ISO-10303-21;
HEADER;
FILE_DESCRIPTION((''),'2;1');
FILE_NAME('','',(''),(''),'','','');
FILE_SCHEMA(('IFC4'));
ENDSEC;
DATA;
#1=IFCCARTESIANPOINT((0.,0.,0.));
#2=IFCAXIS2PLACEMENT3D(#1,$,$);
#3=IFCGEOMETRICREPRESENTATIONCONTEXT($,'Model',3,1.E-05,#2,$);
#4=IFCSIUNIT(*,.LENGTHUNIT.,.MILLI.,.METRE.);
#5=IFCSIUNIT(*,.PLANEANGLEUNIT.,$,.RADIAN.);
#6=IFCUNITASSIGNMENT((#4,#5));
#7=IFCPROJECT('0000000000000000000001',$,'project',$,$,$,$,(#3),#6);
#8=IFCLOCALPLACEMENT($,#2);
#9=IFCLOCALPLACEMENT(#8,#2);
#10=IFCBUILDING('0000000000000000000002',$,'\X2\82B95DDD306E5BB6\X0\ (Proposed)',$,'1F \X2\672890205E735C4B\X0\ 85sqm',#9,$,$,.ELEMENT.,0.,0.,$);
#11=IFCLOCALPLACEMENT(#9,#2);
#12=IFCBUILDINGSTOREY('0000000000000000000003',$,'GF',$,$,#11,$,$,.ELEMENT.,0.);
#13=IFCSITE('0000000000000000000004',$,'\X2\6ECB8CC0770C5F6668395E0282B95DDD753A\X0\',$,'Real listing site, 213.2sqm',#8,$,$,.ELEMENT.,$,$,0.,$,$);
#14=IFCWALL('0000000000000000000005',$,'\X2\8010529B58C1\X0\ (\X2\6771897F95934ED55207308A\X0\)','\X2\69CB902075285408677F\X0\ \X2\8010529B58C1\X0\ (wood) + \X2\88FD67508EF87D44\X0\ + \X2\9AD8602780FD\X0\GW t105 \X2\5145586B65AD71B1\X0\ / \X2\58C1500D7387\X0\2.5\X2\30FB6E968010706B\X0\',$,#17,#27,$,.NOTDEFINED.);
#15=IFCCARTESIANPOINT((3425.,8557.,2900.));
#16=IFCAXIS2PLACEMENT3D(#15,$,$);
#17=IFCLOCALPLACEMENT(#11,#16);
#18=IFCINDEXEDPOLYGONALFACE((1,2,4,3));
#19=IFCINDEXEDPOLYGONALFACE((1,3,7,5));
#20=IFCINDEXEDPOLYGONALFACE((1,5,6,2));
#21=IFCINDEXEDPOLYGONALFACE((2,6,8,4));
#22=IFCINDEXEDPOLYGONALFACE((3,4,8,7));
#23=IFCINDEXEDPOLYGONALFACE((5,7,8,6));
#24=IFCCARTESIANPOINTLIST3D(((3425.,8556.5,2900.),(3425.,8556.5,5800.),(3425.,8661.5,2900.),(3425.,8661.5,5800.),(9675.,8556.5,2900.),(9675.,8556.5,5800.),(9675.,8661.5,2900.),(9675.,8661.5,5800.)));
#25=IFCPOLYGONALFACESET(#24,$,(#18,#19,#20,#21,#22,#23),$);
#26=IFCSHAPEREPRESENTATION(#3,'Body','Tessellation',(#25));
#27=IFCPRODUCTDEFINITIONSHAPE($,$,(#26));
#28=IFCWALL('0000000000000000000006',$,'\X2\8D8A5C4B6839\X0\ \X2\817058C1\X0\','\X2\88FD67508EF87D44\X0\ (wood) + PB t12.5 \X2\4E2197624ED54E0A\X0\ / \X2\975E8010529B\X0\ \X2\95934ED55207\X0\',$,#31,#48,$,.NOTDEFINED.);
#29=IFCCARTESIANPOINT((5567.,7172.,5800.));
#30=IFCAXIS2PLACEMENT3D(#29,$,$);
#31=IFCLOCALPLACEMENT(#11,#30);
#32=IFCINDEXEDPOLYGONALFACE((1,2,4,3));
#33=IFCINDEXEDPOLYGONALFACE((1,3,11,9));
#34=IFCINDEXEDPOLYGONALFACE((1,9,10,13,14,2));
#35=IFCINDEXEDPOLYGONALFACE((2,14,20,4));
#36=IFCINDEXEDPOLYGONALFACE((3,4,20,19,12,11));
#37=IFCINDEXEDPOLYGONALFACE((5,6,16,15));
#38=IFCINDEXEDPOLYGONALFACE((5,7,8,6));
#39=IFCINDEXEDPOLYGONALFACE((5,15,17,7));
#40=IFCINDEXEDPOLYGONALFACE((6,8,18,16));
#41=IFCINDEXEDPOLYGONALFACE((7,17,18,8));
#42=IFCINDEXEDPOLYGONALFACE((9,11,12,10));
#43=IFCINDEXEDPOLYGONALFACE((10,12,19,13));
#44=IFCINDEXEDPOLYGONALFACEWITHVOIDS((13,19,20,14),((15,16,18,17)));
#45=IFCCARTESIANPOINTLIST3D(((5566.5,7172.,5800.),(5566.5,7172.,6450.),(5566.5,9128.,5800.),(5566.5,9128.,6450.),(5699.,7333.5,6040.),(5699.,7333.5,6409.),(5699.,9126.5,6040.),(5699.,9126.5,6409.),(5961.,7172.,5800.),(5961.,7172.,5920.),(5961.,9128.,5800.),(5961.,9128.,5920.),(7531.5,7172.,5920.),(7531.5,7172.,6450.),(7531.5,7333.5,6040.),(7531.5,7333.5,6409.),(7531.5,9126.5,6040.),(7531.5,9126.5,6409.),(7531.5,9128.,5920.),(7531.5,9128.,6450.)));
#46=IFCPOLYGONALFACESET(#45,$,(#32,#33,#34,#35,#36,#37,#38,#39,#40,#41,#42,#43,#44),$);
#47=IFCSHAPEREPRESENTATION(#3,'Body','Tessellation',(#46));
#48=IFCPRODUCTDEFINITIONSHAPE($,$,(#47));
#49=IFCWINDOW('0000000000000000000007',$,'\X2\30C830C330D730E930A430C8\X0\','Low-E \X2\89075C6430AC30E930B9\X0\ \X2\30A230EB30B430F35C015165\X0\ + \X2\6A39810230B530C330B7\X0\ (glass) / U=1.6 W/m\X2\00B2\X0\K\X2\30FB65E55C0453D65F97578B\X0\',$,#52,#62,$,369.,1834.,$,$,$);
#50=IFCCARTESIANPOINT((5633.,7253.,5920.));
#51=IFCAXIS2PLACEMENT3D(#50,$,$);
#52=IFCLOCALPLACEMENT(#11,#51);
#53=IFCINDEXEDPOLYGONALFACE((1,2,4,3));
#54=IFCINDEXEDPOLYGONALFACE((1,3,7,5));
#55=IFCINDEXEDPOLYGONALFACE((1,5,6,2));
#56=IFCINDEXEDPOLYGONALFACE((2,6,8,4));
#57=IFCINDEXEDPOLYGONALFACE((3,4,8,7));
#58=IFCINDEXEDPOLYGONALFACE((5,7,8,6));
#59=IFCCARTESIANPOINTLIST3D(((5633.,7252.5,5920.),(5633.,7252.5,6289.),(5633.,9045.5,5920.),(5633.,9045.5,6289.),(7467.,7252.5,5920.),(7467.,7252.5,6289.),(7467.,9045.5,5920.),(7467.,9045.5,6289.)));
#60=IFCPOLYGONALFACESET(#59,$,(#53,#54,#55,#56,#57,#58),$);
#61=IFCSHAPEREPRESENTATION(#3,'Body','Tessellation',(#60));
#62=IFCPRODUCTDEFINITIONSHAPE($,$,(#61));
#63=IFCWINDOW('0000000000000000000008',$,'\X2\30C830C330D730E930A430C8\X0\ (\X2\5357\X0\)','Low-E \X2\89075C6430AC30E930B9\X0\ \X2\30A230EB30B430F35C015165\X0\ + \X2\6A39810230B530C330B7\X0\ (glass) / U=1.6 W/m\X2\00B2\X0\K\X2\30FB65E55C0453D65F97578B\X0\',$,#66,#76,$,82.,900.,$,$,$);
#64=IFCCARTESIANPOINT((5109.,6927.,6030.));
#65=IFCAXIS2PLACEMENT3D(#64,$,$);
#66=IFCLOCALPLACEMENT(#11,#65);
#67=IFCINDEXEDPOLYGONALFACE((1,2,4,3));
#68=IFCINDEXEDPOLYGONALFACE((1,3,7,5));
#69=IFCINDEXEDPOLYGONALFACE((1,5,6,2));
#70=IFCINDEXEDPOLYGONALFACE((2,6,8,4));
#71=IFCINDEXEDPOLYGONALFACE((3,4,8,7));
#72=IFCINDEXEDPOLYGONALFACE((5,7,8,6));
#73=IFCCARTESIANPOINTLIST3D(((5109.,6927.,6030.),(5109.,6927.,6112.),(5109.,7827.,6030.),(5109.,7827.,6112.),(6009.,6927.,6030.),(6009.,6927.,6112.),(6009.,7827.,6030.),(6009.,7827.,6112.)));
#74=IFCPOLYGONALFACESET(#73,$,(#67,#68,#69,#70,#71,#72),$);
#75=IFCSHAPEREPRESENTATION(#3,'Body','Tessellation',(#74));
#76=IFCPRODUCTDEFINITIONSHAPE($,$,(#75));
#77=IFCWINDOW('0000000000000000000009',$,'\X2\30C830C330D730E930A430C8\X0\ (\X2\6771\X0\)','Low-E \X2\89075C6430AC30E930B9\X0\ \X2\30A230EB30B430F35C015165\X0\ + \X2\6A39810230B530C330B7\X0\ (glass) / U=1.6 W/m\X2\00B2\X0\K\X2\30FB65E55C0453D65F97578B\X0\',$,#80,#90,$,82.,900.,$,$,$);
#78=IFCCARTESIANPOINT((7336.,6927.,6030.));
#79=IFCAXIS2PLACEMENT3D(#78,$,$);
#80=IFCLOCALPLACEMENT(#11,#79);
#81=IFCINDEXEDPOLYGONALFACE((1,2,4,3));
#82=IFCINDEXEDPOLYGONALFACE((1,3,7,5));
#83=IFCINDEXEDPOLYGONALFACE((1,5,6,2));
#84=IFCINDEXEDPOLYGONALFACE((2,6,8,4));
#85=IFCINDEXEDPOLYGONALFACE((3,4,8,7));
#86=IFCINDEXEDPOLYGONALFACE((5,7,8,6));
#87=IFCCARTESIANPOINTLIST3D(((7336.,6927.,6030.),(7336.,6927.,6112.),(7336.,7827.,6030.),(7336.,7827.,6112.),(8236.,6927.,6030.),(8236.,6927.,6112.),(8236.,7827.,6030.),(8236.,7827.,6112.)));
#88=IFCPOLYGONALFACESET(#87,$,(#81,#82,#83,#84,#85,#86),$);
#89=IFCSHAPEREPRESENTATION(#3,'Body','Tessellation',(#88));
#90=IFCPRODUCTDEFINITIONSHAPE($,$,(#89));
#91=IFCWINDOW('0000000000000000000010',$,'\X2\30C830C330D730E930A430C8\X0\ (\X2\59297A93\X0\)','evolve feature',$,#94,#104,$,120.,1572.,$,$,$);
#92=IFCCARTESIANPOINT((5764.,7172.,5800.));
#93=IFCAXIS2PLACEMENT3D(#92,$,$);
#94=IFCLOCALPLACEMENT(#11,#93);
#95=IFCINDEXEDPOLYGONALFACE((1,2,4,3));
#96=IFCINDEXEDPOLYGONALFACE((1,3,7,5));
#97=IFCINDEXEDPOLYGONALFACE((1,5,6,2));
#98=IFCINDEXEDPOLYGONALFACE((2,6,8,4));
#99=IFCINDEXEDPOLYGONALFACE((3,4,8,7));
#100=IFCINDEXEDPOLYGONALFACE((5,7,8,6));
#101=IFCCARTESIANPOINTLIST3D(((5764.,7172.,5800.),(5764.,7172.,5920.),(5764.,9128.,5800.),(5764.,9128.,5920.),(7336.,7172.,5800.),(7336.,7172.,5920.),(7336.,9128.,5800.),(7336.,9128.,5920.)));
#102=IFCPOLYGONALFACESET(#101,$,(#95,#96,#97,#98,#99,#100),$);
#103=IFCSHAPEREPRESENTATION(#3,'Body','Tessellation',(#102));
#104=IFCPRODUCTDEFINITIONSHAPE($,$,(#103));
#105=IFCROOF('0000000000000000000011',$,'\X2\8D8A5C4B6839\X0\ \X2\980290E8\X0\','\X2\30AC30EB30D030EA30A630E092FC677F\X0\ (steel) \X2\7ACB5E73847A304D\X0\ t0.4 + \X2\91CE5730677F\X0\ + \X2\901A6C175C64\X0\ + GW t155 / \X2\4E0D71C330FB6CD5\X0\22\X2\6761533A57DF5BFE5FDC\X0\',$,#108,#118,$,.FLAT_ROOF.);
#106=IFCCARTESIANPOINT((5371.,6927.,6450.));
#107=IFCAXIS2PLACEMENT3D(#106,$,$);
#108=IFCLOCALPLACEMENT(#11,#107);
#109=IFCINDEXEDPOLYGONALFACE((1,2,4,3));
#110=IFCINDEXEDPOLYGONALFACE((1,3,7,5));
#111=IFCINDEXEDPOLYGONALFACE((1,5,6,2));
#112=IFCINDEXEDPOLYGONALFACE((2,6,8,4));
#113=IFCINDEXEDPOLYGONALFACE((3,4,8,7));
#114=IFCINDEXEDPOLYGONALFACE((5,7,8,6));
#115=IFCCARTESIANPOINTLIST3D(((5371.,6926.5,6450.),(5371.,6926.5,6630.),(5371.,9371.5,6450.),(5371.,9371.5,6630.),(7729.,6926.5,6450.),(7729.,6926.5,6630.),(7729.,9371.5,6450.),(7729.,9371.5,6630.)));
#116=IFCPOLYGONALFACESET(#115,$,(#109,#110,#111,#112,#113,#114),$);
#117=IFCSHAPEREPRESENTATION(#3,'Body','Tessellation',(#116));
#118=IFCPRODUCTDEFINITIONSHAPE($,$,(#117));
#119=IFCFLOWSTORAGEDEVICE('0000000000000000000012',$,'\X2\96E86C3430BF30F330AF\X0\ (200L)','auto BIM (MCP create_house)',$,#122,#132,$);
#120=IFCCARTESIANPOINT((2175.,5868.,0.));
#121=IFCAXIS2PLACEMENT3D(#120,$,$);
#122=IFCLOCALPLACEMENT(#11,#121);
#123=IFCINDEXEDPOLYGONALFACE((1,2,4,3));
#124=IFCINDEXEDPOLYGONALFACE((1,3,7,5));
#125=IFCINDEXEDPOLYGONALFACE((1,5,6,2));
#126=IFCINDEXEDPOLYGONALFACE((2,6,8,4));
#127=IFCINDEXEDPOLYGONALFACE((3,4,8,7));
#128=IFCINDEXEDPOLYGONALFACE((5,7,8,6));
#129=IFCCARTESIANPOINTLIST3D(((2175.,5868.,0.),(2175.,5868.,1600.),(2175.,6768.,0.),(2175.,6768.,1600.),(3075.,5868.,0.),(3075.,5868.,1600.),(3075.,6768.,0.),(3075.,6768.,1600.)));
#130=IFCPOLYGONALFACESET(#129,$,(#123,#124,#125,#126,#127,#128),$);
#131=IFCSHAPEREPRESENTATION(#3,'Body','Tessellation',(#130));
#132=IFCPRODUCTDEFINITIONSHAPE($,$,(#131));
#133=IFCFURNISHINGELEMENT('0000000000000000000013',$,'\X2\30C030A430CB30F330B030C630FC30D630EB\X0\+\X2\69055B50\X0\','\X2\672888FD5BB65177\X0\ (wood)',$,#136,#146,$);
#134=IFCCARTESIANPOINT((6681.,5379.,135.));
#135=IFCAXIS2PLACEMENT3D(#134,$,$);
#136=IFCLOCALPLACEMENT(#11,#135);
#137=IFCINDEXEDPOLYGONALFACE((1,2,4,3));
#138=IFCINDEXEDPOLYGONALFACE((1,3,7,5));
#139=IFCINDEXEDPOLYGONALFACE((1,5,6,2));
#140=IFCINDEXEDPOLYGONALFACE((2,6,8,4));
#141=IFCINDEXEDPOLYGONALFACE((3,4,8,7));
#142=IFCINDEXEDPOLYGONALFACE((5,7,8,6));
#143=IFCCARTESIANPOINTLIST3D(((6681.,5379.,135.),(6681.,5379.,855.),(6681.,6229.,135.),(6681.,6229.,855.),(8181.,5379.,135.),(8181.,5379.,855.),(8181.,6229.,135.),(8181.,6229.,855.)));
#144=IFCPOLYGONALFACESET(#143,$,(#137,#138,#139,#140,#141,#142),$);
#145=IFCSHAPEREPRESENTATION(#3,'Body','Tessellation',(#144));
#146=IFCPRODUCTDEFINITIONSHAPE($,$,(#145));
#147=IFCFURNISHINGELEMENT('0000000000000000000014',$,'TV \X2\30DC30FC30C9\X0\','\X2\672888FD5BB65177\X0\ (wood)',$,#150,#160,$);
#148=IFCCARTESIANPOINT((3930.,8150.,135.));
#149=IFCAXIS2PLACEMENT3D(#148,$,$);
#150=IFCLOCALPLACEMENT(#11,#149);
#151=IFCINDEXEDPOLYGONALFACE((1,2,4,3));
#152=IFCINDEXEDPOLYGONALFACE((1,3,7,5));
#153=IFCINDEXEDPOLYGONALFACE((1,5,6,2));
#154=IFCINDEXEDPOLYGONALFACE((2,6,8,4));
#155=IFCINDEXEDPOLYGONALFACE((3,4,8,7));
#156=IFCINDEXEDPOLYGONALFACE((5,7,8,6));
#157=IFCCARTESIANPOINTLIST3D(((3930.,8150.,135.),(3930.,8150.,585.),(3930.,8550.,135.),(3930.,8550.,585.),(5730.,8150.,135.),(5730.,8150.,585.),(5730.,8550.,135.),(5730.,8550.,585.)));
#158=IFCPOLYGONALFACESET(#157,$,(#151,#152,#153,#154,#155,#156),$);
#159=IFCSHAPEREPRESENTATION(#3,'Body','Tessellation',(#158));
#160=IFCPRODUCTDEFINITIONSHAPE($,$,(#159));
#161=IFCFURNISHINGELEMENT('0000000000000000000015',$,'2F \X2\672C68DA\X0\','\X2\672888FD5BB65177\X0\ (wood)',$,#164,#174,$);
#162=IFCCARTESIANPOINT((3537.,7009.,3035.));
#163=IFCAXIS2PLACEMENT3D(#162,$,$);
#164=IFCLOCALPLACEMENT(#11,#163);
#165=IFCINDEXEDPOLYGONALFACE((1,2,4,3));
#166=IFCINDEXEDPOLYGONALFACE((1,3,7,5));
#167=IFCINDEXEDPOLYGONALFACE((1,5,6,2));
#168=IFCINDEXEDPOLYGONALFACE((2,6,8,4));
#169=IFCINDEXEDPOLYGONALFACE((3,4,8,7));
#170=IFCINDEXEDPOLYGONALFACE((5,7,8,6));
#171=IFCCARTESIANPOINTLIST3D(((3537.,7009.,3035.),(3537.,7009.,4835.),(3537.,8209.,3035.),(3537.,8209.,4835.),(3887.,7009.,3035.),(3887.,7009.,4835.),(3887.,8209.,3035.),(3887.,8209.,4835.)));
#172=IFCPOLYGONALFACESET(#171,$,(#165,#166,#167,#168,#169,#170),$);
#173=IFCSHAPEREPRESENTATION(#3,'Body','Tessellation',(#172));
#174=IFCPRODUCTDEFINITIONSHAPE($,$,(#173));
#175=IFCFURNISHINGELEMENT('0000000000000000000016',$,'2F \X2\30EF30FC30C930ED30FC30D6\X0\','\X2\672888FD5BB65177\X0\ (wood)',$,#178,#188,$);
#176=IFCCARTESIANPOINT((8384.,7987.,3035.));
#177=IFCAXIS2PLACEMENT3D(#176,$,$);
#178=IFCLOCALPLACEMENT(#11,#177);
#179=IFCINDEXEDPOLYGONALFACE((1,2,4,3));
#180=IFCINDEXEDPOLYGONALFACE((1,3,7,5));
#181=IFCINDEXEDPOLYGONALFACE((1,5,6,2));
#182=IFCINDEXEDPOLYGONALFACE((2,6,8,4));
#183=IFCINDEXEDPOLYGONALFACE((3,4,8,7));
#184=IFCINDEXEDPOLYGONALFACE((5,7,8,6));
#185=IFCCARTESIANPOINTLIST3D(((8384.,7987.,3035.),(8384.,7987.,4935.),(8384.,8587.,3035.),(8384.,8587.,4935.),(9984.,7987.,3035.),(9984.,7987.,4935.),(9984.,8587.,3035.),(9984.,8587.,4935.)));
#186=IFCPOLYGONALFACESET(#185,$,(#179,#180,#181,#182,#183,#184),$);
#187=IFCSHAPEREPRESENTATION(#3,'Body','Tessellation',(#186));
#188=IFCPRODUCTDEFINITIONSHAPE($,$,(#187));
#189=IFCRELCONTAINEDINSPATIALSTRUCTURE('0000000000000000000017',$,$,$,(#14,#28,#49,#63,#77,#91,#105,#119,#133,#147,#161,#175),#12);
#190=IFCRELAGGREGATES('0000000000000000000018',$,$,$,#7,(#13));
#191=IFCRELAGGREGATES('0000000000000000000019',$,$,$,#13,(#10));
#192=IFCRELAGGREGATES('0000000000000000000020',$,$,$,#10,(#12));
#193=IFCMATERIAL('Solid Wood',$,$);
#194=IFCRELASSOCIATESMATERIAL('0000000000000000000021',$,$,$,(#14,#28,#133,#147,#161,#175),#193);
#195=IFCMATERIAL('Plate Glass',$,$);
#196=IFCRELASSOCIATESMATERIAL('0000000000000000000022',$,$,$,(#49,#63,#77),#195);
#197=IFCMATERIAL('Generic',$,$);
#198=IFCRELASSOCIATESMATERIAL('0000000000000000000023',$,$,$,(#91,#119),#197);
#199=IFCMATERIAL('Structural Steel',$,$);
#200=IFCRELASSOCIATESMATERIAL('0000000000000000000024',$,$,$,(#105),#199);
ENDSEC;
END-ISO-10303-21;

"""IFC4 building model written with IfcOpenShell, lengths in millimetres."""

from ifc_helpers import new_model, si_unit, frame, frame_2d, origin, place, context, project, spatial, rectangle, extrude, material, element, fill, save


model = new_model("IFC4")

# Units and contexts
model_context = context("Model", 3, precision=1e-05, world=origin())
ifc_project = project(units=[si_unit("LENGTHUNIT", "METRE", prefix="MILLI"), si_unit("PLANEANGLEUNIT", "RADIAN")], contexts=[model_context])

# Site, building, storey
site_placement = place(None, origin())
site = spatial("IfcSite", under=ifc_project, at=site_placement, Name="滋賀県彦根市芹川町", ObjectType="Real listing site, 213.2sqm", CompositionType="ELEMENT", RefElevation=0.0)
building_placement = place(site_placement, origin())
building = spatial("IfcBuilding", under=site, at=building_placement, Name="芹川の家 (Proposed)", ObjectType="1F 木造平屋 85sqm", CompositionType="ELEMENT", ElevationOfRefHeight=0.0, ElevationOfTerrain=0.0)
storey_placement = place(building_placement, origin())
storey = spatial("IfcBuildingStorey", under=building, at=storey_placement, Name="GF", CompositionType="ELEMENT", Elevation=0.0)

# Wall
ifc_material_1 = material(Name="Solid Wood")
wall_1_placement = place(storey_placement, frame((3425.0, 8557.0, 2900.0)))
element("IfcWall", 1, at=wall_1_placement, inside=storey, material=ifc_material_1, Name="耐力壁 (東西間仕切り)", Description="構造用合板 耐力壁 (wood) + 製材軸組 + 高性能GW t105 充填断熱 / 壁倍率2.5・準耐火", PredefinedType="NOTDEFINED", context=model_context, shape_type="SweptSolid", body=[
    extrude(rectangle(XDim=6250.0, YDim=105.0, at=frame_2d((3125.0, 52.0))), frame((3425.0, 8557.0, 2900.0)), (0.0, 0.0, 1.0), 2900.0),
])

# Wall, openings, windows
wall_2_placement = place(storey_placement, frame((5567.0, 7172.0, 5800.0)))
wall_2 = element("IfcWall", 2, at=wall_2_placement, inside=storey, material=ifc_material_1, Name="越屋根 腰壁", Description="製材軸組 (wood) + PB t12.5 両面仕上 / 非耐力 間仕切", PredefinedType="NOTDEFINED", context=model_context, shape_type="SweptSolid", body=[
    extrude(rectangle(XDim=1965.0, YDim=1956.0, at=frame_2d((982.0, 978.0))), frame((5567.0, 7172.0, 5800.0)), (0.0, 0.0, 1.0), 650.0),
])
opening_1_placement = place(storey_placement, frame((5633.0, 7253.0, 5920.0)))
opening_1 = element("IfcOpeningElement", 3, at=opening_1_placement, cuts=wall_2, PredefinedType="NOTDEFINED", context=model_context, shape_type="SweptSolid", body=[
    extrude(rectangle(XDim=1834.0, YDim=1793.0, at=frame_2d((917.0, 896.0))), frame((5633.0, 7253.0, 5920.0)), (0.0, 0.0, 1.0), 369.0),
])
opening_2_placement = place(storey_placement, frame((5109.0, 6927.0, 6030.0)))
opening_2 = element("IfcOpeningElement", 4, at=opening_2_placement, cuts=wall_2, PredefinedType="NOTDEFINED", context=model_context, shape_type="SweptSolid", body=[
    extrude(rectangle(XDim=900.0, YDim=900.0, at=frame_2d((450.0, 450.0))), frame((5109.0, 6927.0, 6030.0)), (0.0, 0.0, 1.0), 82.0),
])
opening_3_placement = place(storey_placement, frame((7336.0, 6927.0, 6030.0)))
opening_3 = element("IfcOpeningElement", 5, at=opening_3_placement, cuts=wall_2, PredefinedType="NOTDEFINED", context=model_context, shape_type="SweptSolid", body=[
    extrude(rectangle(XDim=900.0, YDim=900.0, at=frame_2d((450.0, 450.0))), frame((7336.0, 6927.0, 6030.0)), (0.0, 0.0, 1.0), 82.0),
])
opening_4_placement = place(storey_placement, frame((5764.0, 7172.0, 5800.0)))
opening_4 = element("IfcOpeningElement", 6, at=opening_4_placement, cuts=wall_2, PredefinedType="NOTDEFINED", context=model_context, shape_type="SweptSolid", body=[
    extrude(rectangle(XDim=1572.0, YDim=1956.0, at=frame_2d((786.0, 978.0))), frame((5764.0, 7172.0, 5800.0)), (0.0, 0.0, 1.0), 120.0),
])
ifc_material_2 = material(Name="Plate Glass")
window_1_placement = place(storey_placement, frame((5633.0, 7253.0, 5920.0)))
window_1 = element("IfcWindow", 7, at=window_1_placement, inside=storey, material=ifc_material_2, Name="トップライト", Description="Low-E 複層ガラス アルゴン封入 + 樹脂サッシ (glass) / U=1.6 W/m²K・日射取得型", OverallHeight=369.0, OverallWidth=1834.0, context=model_context, shape_type="SweptSolid", body=[
    extrude(rectangle(XDim=1834.0, YDim=1793.0, at=frame_2d((917.0, 896.0))), frame((5633.0, 7253.0, 5920.0)), (0.0, 0.0, 1.0), 369.0),
])
fill(opening_1, window_1)
window_2_placement = place(storey_placement, frame((5109.0, 6927.0, 6030.0)))
window_2 = element("IfcWindow", 8, at=window_2_placement, inside=storey, material=ifc_material_2, Name="トップライト (南)", Description="Low-E 複層ガラス アルゴン封入 + 樹脂サッシ (glass) / U=1.6 W/m²K・日射取得型", OverallHeight=82.0, OverallWidth=900.0, context=model_context, shape_type="SweptSolid", body=[
    extrude(rectangle(XDim=900.0, YDim=900.0, at=frame_2d((450.0, 450.0))), frame((5109.0, 6927.0, 6030.0)), (0.0, 0.0, 1.0), 82.0),
])
fill(opening_2, window_2)
window_3_placement = place(storey_placement, frame((7336.0, 6927.0, 6030.0)))
window_3 = element("IfcWindow", 9, at=window_3_placement, inside=storey, material=ifc_material_2, Name="トップライト (東)", Description="Low-E 複層ガラス アルゴン封入 + 樹脂サッシ (glass) / U=1.6 W/m²K・日射取得型", OverallHeight=82.0, OverallWidth=900.0, context=model_context, shape_type="SweptSolid", body=[
    extrude(rectangle(XDim=900.0, YDim=900.0, at=frame_2d((450.0, 450.0))), frame((7336.0, 6927.0, 6030.0)), (0.0, 0.0, 1.0), 82.0),
])
fill(opening_3, window_3)
ifc_material_3 = material(Name="Generic")
window_4_placement = place(storey_placement, frame((5764.0, 7172.0, 5800.0)))
window_4 = element("IfcWindow", 10, at=window_4_placement, inside=storey, material=ifc_material_3, Name="トップライト (天窓)", Description="evolve feature", OverallHeight=120.0, OverallWidth=1572.0, context=model_context, shape_type="SweptSolid", body=[
    extrude(rectangle(XDim=1572.0, YDim=1956.0, at=frame_2d((786.0, 978.0))), frame((5764.0, 7172.0, 5800.0)), (0.0, 0.0, 1.0), 120.0),
])
fill(opening_4, window_4)

# Roof
ifc_material_4 = material(Name="Structural Steel")
roof_placement = place(storey_placement, frame((5371.0, 6927.0, 6450.0)))
element("IfcRoof", 11, at=roof_placement, inside=storey, material=ifc_material_4, Name="越屋根 頂部", Description="ガルバリウム鋼板 (steel) 立平葺き t0.4 + 野地板 + 通気層 + GW t155 / 不燃・法22条区域対応", PredefinedType="FLAT_ROOF", context=model_context, shape_type="SweptSolid", body=[
    extrude(rectangle(XDim=2358.0, YDim=2445.0, at=frame_2d((1179.0, 1222.0))), frame((5371.0, 6927.0, 6450.0)), (0.0, 0.0, 1.0), 180.0),
])

# Flow storage device
flow_storage_device_placement = place(storey_placement, frame((2175.0, 5868.0, 0.0)))
element("IfcFlowStorageDevice", 12, at=flow_storage_device_placement, inside=storey, material=ifc_material_3, Name="雨水タンク (200L)", Description="auto BIM (MCP create_house)", context=model_context, shape_type="SweptSolid", body=[
    extrude(rectangle(XDim=900.0, YDim=900.0, at=frame_2d((450.0, 450.0))), frame((2175.0, 5868.0, 0.0)), (0.0, 0.0, 1.0), 1600.0),
])

# Furnishing elements
furnishing_1_placement = place(storey_placement, frame((6681.0, 5379.0, 135.0)))
element("IfcFurnishingElement", 13, at=furnishing_1_placement, inside=storey, material=ifc_material_1, Name="ダイニングテーブル+椅子", Description="木製家具 (wood)", context=model_context, shape_type="SweptSolid", body=[
    extrude(rectangle(XDim=1500.0, YDim=850.0, at=frame_2d((750.0, 425.0))), frame((6681.0, 5379.0, 135.0)), (0.0, 0.0, 1.0), 720.0),
])
furnishing_2_placement = place(storey_placement, frame((3930.0, 8150.0, 135.0)))
element("IfcFurnishingElement", 14, at=furnishing_2_placement, inside=storey, material=ifc_material_1, Name="TV ボード", Description="木製家具 (wood)", context=model_context, shape_type="SweptSolid", body=[
    extrude(rectangle(XDim=1800.0, YDim=400.0, at=frame_2d((900.0, 200.0))), frame((3930.0, 8150.0, 135.0)), (0.0, 0.0, 1.0), 450.0),
])
furnishing_3_placement = place(storey_placement, frame((3537.0, 7009.0, 3035.0)))
element("IfcFurnishingElement", 15, at=furnishing_3_placement, inside=storey, material=ifc_material_1, Name="2F 本棚", Description="木製家具 (wood)", context=model_context, shape_type="SweptSolid", body=[
    extrude(rectangle(XDim=350.0, YDim=1200.0, at=frame_2d((175.0, 600.0))), frame((3537.0, 7009.0, 3035.0)), (0.0, 0.0, 1.0), 1800.0),
])
furnishing_4_placement = place(storey_placement, frame((8384.0, 7987.0, 3035.0)))
element("IfcFurnishingElement", 16, at=furnishing_4_placement, inside=storey, material=ifc_material_1, Name="2F ワードローブ", Description="木製家具 (wood)", context=model_context, shape_type="SweptSolid", body=[
    extrude(rectangle(XDim=1600.0, YDim=600.0, at=frame_2d((800.0, 300.0))), frame((8384.0, 7987.0, 3035.0)), (0.0, 0.0, 1.0), 1900.0),
])

save(model, "model.ifc")
